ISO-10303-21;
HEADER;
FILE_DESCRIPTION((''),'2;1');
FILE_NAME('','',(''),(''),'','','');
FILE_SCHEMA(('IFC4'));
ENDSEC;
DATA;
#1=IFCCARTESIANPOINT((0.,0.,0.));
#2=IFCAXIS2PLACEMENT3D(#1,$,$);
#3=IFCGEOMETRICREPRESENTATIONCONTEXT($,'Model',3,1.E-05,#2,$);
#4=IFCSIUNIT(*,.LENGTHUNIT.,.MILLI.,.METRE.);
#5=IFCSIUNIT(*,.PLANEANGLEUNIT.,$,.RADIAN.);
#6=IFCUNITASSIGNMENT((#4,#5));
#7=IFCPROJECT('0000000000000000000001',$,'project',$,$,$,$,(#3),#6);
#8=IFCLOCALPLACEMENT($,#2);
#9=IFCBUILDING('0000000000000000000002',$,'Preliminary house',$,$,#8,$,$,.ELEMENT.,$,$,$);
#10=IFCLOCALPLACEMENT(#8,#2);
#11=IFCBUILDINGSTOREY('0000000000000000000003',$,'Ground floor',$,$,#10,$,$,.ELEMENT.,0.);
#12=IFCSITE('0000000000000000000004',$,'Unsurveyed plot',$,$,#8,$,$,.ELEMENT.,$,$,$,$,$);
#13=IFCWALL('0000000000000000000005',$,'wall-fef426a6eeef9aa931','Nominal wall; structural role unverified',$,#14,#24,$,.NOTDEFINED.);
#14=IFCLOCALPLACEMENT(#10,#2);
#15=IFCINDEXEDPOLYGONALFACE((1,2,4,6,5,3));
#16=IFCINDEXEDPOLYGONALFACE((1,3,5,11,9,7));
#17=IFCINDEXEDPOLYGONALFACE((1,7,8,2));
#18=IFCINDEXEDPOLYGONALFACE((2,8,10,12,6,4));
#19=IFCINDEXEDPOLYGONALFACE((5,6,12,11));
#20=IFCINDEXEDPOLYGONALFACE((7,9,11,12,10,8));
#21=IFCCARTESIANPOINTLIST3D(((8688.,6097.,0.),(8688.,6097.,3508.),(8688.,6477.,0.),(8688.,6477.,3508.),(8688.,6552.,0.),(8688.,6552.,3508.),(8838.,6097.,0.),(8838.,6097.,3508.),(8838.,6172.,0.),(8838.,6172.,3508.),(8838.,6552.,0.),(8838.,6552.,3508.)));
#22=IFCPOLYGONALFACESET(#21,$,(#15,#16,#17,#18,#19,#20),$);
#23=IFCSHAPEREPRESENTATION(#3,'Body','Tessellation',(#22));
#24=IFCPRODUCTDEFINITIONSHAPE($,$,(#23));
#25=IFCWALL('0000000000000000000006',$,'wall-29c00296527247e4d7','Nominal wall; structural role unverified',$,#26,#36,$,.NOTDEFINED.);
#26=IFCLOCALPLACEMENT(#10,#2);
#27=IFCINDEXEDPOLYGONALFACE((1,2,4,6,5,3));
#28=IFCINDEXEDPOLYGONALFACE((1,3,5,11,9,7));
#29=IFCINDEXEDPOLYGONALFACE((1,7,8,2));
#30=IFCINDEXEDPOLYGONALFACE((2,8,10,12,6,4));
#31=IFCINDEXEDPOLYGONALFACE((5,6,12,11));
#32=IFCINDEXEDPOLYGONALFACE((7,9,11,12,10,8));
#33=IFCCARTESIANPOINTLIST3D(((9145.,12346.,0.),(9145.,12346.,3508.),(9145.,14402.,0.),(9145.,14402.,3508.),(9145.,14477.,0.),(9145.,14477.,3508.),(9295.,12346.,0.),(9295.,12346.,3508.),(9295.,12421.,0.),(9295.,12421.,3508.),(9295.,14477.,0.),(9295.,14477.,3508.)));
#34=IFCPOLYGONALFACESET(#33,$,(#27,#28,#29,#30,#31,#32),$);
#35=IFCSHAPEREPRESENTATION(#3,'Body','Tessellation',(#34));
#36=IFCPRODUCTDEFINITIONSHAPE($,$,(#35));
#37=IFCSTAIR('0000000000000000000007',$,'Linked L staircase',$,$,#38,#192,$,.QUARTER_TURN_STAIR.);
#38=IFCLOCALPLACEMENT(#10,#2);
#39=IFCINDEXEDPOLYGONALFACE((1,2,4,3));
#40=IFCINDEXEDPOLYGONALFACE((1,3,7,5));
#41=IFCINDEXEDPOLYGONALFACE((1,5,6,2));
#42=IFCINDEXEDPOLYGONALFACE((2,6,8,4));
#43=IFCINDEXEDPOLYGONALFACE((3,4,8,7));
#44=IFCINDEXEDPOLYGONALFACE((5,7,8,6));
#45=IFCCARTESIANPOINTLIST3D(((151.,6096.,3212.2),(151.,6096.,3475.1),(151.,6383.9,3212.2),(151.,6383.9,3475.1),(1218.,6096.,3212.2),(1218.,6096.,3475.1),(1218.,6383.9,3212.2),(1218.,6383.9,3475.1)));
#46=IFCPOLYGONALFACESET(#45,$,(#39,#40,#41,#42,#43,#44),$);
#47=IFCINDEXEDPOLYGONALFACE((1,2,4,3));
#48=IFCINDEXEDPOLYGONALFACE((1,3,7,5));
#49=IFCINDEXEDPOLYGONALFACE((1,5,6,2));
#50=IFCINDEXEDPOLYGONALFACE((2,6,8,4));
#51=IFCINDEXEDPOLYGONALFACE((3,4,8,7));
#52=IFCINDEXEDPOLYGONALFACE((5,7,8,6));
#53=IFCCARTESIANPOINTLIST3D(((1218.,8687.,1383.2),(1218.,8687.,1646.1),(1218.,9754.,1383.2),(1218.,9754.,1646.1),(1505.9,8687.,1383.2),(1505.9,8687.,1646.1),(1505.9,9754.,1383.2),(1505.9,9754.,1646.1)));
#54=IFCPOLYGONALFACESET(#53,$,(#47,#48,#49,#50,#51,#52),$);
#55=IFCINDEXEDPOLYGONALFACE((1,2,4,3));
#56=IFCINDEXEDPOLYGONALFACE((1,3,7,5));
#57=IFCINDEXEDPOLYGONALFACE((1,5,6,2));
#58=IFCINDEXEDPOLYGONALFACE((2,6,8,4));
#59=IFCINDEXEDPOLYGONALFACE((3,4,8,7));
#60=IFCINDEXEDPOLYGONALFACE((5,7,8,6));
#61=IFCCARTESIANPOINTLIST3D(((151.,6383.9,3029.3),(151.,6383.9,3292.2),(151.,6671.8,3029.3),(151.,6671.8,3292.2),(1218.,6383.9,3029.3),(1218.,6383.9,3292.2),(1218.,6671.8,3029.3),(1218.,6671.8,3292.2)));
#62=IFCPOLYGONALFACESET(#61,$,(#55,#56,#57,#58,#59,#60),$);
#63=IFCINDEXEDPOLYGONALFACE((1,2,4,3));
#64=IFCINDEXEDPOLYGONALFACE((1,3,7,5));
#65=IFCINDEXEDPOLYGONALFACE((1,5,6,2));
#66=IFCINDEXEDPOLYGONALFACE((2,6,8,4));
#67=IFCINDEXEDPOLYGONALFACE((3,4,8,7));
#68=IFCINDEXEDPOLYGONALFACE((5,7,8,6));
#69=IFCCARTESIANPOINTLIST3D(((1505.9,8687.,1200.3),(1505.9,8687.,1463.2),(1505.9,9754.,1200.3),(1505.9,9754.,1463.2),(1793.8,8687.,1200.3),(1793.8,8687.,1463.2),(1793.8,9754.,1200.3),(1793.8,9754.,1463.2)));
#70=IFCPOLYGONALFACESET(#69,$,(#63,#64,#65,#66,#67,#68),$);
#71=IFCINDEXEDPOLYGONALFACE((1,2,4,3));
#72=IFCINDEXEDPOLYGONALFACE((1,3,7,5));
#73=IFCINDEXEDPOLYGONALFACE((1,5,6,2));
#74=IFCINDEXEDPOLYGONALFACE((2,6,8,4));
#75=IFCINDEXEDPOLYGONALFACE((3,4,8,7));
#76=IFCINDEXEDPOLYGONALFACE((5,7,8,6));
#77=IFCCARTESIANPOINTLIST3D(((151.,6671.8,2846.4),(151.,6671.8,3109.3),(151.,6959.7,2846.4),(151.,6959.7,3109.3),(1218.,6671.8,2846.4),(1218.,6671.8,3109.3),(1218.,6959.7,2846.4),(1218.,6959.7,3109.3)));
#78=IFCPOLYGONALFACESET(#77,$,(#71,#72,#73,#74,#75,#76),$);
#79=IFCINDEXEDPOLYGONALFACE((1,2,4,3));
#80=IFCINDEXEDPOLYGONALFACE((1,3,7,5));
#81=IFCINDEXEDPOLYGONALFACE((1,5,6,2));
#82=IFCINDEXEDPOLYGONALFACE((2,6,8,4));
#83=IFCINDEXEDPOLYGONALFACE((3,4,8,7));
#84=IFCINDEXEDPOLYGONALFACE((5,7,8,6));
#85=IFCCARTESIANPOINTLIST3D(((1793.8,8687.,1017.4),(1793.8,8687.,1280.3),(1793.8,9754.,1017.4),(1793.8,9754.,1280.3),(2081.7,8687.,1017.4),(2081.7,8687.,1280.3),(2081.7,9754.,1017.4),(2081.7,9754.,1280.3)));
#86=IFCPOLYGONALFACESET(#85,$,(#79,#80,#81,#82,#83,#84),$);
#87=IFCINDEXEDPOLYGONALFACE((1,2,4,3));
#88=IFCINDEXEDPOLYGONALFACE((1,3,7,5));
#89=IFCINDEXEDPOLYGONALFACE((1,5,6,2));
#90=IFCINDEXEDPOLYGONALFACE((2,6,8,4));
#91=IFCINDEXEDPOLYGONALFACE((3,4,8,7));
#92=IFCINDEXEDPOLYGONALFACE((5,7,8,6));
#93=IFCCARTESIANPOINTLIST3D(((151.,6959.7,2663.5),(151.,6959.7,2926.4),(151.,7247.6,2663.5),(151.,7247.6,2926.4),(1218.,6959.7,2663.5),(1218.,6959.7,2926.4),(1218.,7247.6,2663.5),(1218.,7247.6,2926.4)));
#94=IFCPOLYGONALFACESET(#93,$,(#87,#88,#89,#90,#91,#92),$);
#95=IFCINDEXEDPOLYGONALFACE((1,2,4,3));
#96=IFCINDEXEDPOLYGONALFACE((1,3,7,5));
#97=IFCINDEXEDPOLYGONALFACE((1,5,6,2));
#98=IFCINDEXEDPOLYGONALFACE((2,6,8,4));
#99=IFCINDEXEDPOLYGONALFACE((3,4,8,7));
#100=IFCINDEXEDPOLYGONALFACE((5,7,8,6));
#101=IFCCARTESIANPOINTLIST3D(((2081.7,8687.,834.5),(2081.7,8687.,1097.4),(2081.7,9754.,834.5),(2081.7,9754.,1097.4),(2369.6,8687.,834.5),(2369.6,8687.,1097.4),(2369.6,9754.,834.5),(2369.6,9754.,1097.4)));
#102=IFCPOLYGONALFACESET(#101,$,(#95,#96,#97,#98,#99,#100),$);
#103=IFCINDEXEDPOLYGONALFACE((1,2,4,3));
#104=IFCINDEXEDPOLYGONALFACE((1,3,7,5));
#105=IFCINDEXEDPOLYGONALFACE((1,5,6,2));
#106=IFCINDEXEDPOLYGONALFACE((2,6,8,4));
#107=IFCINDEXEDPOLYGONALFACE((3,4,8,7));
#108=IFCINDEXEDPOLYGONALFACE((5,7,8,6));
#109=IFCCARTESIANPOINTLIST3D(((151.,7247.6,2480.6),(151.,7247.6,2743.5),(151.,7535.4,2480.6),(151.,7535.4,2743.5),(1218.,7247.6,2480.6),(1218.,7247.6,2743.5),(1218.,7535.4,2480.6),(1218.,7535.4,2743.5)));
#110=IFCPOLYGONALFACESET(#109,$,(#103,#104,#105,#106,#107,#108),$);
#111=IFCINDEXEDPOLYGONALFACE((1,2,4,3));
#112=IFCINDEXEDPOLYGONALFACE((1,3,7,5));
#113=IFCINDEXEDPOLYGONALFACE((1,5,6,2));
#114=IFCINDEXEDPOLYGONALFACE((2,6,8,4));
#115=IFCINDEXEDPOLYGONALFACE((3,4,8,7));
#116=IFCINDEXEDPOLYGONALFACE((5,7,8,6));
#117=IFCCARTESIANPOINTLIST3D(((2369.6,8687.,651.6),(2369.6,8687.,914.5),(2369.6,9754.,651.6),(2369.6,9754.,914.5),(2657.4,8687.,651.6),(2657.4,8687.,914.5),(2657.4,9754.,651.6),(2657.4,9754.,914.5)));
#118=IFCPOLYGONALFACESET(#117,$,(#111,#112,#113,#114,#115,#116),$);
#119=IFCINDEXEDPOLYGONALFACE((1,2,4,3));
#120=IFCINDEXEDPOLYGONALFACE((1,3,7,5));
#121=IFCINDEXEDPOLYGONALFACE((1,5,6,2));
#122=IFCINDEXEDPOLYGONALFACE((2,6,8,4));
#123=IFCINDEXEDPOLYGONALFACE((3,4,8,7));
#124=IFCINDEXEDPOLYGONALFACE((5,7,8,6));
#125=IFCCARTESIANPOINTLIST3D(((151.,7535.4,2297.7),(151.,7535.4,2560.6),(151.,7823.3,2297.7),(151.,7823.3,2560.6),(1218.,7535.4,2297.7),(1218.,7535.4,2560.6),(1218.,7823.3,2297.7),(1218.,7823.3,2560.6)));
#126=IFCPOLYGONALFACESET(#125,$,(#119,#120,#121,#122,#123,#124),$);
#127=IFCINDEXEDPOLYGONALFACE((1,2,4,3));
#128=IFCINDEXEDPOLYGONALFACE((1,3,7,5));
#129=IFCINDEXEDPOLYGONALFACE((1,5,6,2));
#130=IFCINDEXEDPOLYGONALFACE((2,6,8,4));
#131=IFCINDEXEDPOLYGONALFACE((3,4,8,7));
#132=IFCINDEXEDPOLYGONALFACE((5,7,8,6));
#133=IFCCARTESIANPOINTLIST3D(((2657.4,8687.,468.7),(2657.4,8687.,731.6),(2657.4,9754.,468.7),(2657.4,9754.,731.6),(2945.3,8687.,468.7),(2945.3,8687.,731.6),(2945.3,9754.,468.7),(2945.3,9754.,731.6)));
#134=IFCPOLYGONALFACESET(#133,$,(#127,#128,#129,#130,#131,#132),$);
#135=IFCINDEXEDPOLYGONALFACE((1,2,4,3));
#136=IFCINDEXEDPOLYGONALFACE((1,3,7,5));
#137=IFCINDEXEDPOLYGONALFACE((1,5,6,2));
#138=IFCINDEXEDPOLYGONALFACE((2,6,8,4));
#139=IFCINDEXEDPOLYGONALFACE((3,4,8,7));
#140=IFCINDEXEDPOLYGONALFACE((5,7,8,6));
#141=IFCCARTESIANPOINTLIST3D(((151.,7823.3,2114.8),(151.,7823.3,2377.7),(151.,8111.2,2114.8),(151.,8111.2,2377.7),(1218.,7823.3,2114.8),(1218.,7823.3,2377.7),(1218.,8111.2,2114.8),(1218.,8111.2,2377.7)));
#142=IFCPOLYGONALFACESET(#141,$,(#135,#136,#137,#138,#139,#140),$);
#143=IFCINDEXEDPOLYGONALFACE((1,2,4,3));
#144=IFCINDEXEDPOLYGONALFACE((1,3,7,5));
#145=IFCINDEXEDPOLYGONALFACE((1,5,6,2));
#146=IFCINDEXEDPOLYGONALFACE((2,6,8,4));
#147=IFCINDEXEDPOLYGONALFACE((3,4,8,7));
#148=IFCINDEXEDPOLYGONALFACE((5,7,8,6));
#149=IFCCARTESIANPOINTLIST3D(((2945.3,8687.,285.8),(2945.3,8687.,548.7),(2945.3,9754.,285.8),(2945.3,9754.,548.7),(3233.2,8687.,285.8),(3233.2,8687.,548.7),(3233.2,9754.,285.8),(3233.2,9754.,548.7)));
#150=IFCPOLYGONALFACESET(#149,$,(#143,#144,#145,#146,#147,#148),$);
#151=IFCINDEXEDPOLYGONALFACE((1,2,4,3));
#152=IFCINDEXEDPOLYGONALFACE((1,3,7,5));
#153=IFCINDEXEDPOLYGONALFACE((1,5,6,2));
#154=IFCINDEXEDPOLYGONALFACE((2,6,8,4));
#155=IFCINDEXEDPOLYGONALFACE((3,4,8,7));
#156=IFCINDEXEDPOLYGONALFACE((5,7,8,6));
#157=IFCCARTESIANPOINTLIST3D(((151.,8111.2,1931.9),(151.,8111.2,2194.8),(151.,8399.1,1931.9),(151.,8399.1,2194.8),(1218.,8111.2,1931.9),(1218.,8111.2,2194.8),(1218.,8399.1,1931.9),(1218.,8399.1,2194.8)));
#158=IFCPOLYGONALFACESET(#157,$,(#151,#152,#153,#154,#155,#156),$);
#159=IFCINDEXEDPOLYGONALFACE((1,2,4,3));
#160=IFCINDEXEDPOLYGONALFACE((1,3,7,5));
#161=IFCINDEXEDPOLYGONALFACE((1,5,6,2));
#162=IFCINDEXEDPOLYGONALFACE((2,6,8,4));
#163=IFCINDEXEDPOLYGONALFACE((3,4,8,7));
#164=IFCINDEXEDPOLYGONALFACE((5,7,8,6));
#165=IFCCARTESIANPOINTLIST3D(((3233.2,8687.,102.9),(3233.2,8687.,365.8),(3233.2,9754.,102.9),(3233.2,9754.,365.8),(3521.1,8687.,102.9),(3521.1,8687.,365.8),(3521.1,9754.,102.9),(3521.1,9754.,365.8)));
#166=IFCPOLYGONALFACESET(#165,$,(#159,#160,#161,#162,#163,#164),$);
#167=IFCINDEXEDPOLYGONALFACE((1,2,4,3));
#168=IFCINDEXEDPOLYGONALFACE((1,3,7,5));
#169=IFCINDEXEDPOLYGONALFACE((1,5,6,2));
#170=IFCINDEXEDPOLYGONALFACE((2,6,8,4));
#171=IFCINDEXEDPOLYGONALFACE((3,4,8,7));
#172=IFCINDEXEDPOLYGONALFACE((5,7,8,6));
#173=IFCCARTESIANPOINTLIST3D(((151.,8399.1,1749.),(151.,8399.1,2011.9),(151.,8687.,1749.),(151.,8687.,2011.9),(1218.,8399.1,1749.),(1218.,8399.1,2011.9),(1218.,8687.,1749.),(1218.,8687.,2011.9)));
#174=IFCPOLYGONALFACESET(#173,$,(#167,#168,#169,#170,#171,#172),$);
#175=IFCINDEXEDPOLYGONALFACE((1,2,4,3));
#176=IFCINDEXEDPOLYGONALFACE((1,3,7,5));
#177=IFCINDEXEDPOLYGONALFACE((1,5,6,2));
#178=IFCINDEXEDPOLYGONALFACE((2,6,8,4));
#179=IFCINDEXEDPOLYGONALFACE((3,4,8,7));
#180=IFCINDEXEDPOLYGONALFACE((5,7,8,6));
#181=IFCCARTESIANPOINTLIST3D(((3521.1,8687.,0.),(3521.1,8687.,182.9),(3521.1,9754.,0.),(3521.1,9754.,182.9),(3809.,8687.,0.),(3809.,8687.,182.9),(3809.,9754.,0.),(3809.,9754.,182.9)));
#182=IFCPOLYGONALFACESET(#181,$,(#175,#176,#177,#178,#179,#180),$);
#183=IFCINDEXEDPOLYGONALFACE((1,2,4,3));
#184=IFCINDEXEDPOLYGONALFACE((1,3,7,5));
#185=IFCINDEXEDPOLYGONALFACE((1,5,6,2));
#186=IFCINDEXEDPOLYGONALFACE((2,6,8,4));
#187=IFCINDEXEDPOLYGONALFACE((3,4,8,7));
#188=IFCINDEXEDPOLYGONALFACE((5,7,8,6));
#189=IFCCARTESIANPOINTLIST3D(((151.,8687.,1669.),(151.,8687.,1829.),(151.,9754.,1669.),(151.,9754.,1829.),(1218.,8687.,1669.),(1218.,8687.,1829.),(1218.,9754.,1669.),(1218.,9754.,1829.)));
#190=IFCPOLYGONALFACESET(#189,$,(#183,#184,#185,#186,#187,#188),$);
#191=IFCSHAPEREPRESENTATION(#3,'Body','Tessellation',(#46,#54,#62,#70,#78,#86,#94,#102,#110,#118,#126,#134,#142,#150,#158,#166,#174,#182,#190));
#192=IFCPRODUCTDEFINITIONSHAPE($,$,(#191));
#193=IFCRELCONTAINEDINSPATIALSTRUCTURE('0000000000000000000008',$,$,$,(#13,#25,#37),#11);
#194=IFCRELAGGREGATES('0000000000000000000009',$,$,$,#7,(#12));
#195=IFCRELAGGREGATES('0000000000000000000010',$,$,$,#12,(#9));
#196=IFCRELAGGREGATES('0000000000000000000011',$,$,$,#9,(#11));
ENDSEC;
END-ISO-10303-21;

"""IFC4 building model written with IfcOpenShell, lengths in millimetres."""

from ifc_helpers import new_model, si_unit, frame, origin, place, context, project, spatial, polyline, outline, extrude, element, save


model = new_model("IFC4")

# Units and contexts
model_context = context("Model", 3, precision=1e-05, world=origin())
ifc_project = project(units=[si_unit("LENGTHUNIT", "METRE", prefix="MILLI"), si_unit("PLANEANGLEUNIT", "RADIAN")], contexts=[model_context])

# Site, building, storey
placement_1 = place(None, origin())
site = spatial("IfcSite", under=ifc_project, at=placement_1, Name="Unsurveyed plot", CompositionType="ELEMENT")
building = spatial("IfcBuilding", under=site, at=placement_1, Name="Preliminary house", CompositionType="ELEMENT")
placement_2 = place(placement_1, origin())
storey = spatial("IfcBuildingStorey", under=building, at=placement_2, Name="Ground floor", CompositionType="ELEMENT", Elevation=0.0)

# Wall
element("IfcWall", 1, at=placement_2, inside=storey, Name="wall-fef426a6eeef9aa931", Description="Nominal wall; structural role unverified", PredefinedType="NOTDEFINED", context=model_context, shape_type="SweptSolid", body=[
    extrude(outline(polyline([(8688.0, 6477.0), (8688.0, 6552.0), (8838.0, 6552.0), (8838.0, 6172.0), (8838.0, 6097.0), (8688.0, 6097.0), (8688.0, 6477.0)])), origin(), (0.0, 0.0, 1.0), 3508.0),
])

# Wall
element("IfcWall", 2, at=placement_2, inside=storey, Name="wall-29c00296527247e4d7", Description="Nominal wall; structural role unverified", PredefinedType="NOTDEFINED", context=model_context, shape_type="SweptSolid", body=[
    extrude(outline(polyline([(9145.0, 14402.0), (9145.0, 14477.0), (9295.0, 14477.0), (9295.0, 12421.0), (9295.0, 12346.0), (9145.0, 12346.0), (9145.0, 14402.0)])), origin(), (0.0, 0.0, 1.0), 3508.0),
])

# Stair
element("IfcStair", 3, at=placement_2, inside=storey, Name="Linked L staircase", PredefinedType="QUARTER_TURN_STAIR", context=model_context, shape_type="SweptSolid", body=[
    extrude(outline(polyline([(1218.0, 6096.0), (1218.0, 6383.9), (151.0, 6383.9), (151.0, 6096.0), (1218.0, 6096.0)])), frame((0.0, 0.0, 3212.2)), (0.0, 0.0, 1.0), 262.9),
    extrude(outline(polyline([(1505.9, 8687.0), (1505.9, 9754.0), (1218.0, 9754.0), (1218.0, 8687.0), (1505.9, 8687.0)])), frame((0.0, 0.0, 1383.2)), (0.0, 0.0, 1.0), 262.9),
    extrude(outline(polyline([(1218.0, 6383.9), (1218.0, 6671.8), (151.0, 6671.8), (151.0, 6383.9), (1218.0, 6383.9)])), frame((0.0, 0.0, 3029.3)), (0.0, 0.0, 1.0), 262.9),
    extrude(outline(polyline([(1793.8, 8687.0), (1793.8, 9754.0), (1505.9, 9754.0), (1505.9, 8687.0), (1793.8, 8687.0)])), frame((0.0, 0.0, 1200.3)), (0.0, 0.0, 1.0), 262.9),
    extrude(outline(polyline([(1218.0, 6671.8), (1218.0, 6959.7), (151.0, 6959.7), (151.0, 6671.8), (1218.0, 6671.8)])), frame((0.0, 0.0, 2846.4)), (0.0, 0.0, 1.0), 262.9),
    extrude(outline(polyline([(2081.7, 8687.0), (2081.7, 9754.0), (1793.8, 9754.0), (1793.8, 8687.0), (2081.7, 8687.0)])), frame((0.0, 0.0, 1017.4)), (0.0, 0.0, 1.0), 262.9),
    extrude(outline(polyline([(1218.0, 6959.7), (1218.0, 7247.6), (151.0, 7247.6), (151.0, 6959.7), (1218.0, 6959.7)])), frame((0.0, 0.0, 2663.5)), (0.0, 0.0, 1.0), 262.9),
    extrude(outline(polyline([(2369.6, 8687.0), (2369.6, 9754.0), (2081.7, 9754.0), (2081.7, 8687.0), (2369.6, 8687.0)])), frame((0.0, 0.0, 834.5)), (0.0, 0.0, 1.0), 262.9),
    extrude(outline(polyline([(1218.0, 7247.6), (1218.0, 7535.4), (151.0, 7535.4), (151.0, 7247.6), (1218.0, 7247.6)])), frame((0.0, 0.0, 2480.6)), (0.0, 0.0, 1.0), 262.9),
    extrude(outline(polyline([(2657.4, 8687.0), (2657.4, 9754.0), (2369.6, 9754.0), (2369.6, 8687.0), (2657.4, 8687.0)])), frame((0.0, 0.0, 651.6)), (0.0, 0.0, 1.0), 262.9),
    extrude(outline(polyline([(1218.0, 7535.4), (1218.0, 7823.3), (151.0, 7823.3), (151.0, 7535.4), (1218.0, 7535.4)])), frame((0.0, 0.0, 2297.7)), (0.0, 0.0, 1.0), 262.9),
    extrude(outline(polyline([(2945.3, 8687.0), (2945.3, 9754.0), (2657.4, 9754.0), (2657.4, 8687.0), (2945.3, 8687.0)])), frame((0.0, 0.0, 468.7)), (0.0, 0.0, 1.0), 262.9),
    extrude(outline(polyline([(1218.0, 7823.3), (1218.0, 8111.2), (151.0, 8111.2), (151.0, 7823.3), (1218.0, 7823.3)])), frame((0.0, 0.0, 2114.8)), (0.0, 0.0, 1.0), 262.9),
    extrude(outline(polyline([(3233.2, 8687.0), (3233.2, 9754.0), (2945.3, 9754.0), (2945.3, 8687.0), (3233.2, 8687.0)])), frame((0.0, 0.0, 285.8)), (0.0, 0.0, 1.0), 262.9),
    extrude(outline(polyline([(1218.0, 8111.2), (1218.0, 8399.1), (151.0, 8399.1), (151.0, 8111.2), (1218.0, 8111.2)])), frame((0.0, 0.0, 1931.9)), (0.0, 0.0, 1.0), 262.9),
    extrude(outline(polyline([(3521.1, 8687.0), (3521.1, 9754.0), (3233.2, 9754.0), (3233.2, 8687.0), (3521.1, 8687.0)])), frame((0.0, 0.0, 102.9)), (0.0, 0.0, 1.0), 262.9),
    extrude(outline(polyline([(1218.0, 8399.1), (1218.0, 8687.0), (151.0, 8687.0), (151.0, 8399.1), (1218.0, 8399.1)])), frame((0.0, 0.0, 1749.0)), (0.0, 0.0, 1.0), 262.9),
    extrude(outline(polyline([(3809.0, 8687.0), (3809.0, 9754.0), (3521.1, 9754.0), (3521.1, 8687.0), (3809.0, 8687.0)])), origin(), (0.0, 0.0, 1.0), 182.9),
    extrude(outline(polyline([(1218.0, 8687.0), (1218.0, 9754.0), (151.0, 9754.0), (151.0, 8687.0), (1218.0, 8687.0)])), frame((0.0, 0.0, 1669.0)), (0.0, 0.0, 1.0), 160.0),
])

save(model, "model.ifc")
